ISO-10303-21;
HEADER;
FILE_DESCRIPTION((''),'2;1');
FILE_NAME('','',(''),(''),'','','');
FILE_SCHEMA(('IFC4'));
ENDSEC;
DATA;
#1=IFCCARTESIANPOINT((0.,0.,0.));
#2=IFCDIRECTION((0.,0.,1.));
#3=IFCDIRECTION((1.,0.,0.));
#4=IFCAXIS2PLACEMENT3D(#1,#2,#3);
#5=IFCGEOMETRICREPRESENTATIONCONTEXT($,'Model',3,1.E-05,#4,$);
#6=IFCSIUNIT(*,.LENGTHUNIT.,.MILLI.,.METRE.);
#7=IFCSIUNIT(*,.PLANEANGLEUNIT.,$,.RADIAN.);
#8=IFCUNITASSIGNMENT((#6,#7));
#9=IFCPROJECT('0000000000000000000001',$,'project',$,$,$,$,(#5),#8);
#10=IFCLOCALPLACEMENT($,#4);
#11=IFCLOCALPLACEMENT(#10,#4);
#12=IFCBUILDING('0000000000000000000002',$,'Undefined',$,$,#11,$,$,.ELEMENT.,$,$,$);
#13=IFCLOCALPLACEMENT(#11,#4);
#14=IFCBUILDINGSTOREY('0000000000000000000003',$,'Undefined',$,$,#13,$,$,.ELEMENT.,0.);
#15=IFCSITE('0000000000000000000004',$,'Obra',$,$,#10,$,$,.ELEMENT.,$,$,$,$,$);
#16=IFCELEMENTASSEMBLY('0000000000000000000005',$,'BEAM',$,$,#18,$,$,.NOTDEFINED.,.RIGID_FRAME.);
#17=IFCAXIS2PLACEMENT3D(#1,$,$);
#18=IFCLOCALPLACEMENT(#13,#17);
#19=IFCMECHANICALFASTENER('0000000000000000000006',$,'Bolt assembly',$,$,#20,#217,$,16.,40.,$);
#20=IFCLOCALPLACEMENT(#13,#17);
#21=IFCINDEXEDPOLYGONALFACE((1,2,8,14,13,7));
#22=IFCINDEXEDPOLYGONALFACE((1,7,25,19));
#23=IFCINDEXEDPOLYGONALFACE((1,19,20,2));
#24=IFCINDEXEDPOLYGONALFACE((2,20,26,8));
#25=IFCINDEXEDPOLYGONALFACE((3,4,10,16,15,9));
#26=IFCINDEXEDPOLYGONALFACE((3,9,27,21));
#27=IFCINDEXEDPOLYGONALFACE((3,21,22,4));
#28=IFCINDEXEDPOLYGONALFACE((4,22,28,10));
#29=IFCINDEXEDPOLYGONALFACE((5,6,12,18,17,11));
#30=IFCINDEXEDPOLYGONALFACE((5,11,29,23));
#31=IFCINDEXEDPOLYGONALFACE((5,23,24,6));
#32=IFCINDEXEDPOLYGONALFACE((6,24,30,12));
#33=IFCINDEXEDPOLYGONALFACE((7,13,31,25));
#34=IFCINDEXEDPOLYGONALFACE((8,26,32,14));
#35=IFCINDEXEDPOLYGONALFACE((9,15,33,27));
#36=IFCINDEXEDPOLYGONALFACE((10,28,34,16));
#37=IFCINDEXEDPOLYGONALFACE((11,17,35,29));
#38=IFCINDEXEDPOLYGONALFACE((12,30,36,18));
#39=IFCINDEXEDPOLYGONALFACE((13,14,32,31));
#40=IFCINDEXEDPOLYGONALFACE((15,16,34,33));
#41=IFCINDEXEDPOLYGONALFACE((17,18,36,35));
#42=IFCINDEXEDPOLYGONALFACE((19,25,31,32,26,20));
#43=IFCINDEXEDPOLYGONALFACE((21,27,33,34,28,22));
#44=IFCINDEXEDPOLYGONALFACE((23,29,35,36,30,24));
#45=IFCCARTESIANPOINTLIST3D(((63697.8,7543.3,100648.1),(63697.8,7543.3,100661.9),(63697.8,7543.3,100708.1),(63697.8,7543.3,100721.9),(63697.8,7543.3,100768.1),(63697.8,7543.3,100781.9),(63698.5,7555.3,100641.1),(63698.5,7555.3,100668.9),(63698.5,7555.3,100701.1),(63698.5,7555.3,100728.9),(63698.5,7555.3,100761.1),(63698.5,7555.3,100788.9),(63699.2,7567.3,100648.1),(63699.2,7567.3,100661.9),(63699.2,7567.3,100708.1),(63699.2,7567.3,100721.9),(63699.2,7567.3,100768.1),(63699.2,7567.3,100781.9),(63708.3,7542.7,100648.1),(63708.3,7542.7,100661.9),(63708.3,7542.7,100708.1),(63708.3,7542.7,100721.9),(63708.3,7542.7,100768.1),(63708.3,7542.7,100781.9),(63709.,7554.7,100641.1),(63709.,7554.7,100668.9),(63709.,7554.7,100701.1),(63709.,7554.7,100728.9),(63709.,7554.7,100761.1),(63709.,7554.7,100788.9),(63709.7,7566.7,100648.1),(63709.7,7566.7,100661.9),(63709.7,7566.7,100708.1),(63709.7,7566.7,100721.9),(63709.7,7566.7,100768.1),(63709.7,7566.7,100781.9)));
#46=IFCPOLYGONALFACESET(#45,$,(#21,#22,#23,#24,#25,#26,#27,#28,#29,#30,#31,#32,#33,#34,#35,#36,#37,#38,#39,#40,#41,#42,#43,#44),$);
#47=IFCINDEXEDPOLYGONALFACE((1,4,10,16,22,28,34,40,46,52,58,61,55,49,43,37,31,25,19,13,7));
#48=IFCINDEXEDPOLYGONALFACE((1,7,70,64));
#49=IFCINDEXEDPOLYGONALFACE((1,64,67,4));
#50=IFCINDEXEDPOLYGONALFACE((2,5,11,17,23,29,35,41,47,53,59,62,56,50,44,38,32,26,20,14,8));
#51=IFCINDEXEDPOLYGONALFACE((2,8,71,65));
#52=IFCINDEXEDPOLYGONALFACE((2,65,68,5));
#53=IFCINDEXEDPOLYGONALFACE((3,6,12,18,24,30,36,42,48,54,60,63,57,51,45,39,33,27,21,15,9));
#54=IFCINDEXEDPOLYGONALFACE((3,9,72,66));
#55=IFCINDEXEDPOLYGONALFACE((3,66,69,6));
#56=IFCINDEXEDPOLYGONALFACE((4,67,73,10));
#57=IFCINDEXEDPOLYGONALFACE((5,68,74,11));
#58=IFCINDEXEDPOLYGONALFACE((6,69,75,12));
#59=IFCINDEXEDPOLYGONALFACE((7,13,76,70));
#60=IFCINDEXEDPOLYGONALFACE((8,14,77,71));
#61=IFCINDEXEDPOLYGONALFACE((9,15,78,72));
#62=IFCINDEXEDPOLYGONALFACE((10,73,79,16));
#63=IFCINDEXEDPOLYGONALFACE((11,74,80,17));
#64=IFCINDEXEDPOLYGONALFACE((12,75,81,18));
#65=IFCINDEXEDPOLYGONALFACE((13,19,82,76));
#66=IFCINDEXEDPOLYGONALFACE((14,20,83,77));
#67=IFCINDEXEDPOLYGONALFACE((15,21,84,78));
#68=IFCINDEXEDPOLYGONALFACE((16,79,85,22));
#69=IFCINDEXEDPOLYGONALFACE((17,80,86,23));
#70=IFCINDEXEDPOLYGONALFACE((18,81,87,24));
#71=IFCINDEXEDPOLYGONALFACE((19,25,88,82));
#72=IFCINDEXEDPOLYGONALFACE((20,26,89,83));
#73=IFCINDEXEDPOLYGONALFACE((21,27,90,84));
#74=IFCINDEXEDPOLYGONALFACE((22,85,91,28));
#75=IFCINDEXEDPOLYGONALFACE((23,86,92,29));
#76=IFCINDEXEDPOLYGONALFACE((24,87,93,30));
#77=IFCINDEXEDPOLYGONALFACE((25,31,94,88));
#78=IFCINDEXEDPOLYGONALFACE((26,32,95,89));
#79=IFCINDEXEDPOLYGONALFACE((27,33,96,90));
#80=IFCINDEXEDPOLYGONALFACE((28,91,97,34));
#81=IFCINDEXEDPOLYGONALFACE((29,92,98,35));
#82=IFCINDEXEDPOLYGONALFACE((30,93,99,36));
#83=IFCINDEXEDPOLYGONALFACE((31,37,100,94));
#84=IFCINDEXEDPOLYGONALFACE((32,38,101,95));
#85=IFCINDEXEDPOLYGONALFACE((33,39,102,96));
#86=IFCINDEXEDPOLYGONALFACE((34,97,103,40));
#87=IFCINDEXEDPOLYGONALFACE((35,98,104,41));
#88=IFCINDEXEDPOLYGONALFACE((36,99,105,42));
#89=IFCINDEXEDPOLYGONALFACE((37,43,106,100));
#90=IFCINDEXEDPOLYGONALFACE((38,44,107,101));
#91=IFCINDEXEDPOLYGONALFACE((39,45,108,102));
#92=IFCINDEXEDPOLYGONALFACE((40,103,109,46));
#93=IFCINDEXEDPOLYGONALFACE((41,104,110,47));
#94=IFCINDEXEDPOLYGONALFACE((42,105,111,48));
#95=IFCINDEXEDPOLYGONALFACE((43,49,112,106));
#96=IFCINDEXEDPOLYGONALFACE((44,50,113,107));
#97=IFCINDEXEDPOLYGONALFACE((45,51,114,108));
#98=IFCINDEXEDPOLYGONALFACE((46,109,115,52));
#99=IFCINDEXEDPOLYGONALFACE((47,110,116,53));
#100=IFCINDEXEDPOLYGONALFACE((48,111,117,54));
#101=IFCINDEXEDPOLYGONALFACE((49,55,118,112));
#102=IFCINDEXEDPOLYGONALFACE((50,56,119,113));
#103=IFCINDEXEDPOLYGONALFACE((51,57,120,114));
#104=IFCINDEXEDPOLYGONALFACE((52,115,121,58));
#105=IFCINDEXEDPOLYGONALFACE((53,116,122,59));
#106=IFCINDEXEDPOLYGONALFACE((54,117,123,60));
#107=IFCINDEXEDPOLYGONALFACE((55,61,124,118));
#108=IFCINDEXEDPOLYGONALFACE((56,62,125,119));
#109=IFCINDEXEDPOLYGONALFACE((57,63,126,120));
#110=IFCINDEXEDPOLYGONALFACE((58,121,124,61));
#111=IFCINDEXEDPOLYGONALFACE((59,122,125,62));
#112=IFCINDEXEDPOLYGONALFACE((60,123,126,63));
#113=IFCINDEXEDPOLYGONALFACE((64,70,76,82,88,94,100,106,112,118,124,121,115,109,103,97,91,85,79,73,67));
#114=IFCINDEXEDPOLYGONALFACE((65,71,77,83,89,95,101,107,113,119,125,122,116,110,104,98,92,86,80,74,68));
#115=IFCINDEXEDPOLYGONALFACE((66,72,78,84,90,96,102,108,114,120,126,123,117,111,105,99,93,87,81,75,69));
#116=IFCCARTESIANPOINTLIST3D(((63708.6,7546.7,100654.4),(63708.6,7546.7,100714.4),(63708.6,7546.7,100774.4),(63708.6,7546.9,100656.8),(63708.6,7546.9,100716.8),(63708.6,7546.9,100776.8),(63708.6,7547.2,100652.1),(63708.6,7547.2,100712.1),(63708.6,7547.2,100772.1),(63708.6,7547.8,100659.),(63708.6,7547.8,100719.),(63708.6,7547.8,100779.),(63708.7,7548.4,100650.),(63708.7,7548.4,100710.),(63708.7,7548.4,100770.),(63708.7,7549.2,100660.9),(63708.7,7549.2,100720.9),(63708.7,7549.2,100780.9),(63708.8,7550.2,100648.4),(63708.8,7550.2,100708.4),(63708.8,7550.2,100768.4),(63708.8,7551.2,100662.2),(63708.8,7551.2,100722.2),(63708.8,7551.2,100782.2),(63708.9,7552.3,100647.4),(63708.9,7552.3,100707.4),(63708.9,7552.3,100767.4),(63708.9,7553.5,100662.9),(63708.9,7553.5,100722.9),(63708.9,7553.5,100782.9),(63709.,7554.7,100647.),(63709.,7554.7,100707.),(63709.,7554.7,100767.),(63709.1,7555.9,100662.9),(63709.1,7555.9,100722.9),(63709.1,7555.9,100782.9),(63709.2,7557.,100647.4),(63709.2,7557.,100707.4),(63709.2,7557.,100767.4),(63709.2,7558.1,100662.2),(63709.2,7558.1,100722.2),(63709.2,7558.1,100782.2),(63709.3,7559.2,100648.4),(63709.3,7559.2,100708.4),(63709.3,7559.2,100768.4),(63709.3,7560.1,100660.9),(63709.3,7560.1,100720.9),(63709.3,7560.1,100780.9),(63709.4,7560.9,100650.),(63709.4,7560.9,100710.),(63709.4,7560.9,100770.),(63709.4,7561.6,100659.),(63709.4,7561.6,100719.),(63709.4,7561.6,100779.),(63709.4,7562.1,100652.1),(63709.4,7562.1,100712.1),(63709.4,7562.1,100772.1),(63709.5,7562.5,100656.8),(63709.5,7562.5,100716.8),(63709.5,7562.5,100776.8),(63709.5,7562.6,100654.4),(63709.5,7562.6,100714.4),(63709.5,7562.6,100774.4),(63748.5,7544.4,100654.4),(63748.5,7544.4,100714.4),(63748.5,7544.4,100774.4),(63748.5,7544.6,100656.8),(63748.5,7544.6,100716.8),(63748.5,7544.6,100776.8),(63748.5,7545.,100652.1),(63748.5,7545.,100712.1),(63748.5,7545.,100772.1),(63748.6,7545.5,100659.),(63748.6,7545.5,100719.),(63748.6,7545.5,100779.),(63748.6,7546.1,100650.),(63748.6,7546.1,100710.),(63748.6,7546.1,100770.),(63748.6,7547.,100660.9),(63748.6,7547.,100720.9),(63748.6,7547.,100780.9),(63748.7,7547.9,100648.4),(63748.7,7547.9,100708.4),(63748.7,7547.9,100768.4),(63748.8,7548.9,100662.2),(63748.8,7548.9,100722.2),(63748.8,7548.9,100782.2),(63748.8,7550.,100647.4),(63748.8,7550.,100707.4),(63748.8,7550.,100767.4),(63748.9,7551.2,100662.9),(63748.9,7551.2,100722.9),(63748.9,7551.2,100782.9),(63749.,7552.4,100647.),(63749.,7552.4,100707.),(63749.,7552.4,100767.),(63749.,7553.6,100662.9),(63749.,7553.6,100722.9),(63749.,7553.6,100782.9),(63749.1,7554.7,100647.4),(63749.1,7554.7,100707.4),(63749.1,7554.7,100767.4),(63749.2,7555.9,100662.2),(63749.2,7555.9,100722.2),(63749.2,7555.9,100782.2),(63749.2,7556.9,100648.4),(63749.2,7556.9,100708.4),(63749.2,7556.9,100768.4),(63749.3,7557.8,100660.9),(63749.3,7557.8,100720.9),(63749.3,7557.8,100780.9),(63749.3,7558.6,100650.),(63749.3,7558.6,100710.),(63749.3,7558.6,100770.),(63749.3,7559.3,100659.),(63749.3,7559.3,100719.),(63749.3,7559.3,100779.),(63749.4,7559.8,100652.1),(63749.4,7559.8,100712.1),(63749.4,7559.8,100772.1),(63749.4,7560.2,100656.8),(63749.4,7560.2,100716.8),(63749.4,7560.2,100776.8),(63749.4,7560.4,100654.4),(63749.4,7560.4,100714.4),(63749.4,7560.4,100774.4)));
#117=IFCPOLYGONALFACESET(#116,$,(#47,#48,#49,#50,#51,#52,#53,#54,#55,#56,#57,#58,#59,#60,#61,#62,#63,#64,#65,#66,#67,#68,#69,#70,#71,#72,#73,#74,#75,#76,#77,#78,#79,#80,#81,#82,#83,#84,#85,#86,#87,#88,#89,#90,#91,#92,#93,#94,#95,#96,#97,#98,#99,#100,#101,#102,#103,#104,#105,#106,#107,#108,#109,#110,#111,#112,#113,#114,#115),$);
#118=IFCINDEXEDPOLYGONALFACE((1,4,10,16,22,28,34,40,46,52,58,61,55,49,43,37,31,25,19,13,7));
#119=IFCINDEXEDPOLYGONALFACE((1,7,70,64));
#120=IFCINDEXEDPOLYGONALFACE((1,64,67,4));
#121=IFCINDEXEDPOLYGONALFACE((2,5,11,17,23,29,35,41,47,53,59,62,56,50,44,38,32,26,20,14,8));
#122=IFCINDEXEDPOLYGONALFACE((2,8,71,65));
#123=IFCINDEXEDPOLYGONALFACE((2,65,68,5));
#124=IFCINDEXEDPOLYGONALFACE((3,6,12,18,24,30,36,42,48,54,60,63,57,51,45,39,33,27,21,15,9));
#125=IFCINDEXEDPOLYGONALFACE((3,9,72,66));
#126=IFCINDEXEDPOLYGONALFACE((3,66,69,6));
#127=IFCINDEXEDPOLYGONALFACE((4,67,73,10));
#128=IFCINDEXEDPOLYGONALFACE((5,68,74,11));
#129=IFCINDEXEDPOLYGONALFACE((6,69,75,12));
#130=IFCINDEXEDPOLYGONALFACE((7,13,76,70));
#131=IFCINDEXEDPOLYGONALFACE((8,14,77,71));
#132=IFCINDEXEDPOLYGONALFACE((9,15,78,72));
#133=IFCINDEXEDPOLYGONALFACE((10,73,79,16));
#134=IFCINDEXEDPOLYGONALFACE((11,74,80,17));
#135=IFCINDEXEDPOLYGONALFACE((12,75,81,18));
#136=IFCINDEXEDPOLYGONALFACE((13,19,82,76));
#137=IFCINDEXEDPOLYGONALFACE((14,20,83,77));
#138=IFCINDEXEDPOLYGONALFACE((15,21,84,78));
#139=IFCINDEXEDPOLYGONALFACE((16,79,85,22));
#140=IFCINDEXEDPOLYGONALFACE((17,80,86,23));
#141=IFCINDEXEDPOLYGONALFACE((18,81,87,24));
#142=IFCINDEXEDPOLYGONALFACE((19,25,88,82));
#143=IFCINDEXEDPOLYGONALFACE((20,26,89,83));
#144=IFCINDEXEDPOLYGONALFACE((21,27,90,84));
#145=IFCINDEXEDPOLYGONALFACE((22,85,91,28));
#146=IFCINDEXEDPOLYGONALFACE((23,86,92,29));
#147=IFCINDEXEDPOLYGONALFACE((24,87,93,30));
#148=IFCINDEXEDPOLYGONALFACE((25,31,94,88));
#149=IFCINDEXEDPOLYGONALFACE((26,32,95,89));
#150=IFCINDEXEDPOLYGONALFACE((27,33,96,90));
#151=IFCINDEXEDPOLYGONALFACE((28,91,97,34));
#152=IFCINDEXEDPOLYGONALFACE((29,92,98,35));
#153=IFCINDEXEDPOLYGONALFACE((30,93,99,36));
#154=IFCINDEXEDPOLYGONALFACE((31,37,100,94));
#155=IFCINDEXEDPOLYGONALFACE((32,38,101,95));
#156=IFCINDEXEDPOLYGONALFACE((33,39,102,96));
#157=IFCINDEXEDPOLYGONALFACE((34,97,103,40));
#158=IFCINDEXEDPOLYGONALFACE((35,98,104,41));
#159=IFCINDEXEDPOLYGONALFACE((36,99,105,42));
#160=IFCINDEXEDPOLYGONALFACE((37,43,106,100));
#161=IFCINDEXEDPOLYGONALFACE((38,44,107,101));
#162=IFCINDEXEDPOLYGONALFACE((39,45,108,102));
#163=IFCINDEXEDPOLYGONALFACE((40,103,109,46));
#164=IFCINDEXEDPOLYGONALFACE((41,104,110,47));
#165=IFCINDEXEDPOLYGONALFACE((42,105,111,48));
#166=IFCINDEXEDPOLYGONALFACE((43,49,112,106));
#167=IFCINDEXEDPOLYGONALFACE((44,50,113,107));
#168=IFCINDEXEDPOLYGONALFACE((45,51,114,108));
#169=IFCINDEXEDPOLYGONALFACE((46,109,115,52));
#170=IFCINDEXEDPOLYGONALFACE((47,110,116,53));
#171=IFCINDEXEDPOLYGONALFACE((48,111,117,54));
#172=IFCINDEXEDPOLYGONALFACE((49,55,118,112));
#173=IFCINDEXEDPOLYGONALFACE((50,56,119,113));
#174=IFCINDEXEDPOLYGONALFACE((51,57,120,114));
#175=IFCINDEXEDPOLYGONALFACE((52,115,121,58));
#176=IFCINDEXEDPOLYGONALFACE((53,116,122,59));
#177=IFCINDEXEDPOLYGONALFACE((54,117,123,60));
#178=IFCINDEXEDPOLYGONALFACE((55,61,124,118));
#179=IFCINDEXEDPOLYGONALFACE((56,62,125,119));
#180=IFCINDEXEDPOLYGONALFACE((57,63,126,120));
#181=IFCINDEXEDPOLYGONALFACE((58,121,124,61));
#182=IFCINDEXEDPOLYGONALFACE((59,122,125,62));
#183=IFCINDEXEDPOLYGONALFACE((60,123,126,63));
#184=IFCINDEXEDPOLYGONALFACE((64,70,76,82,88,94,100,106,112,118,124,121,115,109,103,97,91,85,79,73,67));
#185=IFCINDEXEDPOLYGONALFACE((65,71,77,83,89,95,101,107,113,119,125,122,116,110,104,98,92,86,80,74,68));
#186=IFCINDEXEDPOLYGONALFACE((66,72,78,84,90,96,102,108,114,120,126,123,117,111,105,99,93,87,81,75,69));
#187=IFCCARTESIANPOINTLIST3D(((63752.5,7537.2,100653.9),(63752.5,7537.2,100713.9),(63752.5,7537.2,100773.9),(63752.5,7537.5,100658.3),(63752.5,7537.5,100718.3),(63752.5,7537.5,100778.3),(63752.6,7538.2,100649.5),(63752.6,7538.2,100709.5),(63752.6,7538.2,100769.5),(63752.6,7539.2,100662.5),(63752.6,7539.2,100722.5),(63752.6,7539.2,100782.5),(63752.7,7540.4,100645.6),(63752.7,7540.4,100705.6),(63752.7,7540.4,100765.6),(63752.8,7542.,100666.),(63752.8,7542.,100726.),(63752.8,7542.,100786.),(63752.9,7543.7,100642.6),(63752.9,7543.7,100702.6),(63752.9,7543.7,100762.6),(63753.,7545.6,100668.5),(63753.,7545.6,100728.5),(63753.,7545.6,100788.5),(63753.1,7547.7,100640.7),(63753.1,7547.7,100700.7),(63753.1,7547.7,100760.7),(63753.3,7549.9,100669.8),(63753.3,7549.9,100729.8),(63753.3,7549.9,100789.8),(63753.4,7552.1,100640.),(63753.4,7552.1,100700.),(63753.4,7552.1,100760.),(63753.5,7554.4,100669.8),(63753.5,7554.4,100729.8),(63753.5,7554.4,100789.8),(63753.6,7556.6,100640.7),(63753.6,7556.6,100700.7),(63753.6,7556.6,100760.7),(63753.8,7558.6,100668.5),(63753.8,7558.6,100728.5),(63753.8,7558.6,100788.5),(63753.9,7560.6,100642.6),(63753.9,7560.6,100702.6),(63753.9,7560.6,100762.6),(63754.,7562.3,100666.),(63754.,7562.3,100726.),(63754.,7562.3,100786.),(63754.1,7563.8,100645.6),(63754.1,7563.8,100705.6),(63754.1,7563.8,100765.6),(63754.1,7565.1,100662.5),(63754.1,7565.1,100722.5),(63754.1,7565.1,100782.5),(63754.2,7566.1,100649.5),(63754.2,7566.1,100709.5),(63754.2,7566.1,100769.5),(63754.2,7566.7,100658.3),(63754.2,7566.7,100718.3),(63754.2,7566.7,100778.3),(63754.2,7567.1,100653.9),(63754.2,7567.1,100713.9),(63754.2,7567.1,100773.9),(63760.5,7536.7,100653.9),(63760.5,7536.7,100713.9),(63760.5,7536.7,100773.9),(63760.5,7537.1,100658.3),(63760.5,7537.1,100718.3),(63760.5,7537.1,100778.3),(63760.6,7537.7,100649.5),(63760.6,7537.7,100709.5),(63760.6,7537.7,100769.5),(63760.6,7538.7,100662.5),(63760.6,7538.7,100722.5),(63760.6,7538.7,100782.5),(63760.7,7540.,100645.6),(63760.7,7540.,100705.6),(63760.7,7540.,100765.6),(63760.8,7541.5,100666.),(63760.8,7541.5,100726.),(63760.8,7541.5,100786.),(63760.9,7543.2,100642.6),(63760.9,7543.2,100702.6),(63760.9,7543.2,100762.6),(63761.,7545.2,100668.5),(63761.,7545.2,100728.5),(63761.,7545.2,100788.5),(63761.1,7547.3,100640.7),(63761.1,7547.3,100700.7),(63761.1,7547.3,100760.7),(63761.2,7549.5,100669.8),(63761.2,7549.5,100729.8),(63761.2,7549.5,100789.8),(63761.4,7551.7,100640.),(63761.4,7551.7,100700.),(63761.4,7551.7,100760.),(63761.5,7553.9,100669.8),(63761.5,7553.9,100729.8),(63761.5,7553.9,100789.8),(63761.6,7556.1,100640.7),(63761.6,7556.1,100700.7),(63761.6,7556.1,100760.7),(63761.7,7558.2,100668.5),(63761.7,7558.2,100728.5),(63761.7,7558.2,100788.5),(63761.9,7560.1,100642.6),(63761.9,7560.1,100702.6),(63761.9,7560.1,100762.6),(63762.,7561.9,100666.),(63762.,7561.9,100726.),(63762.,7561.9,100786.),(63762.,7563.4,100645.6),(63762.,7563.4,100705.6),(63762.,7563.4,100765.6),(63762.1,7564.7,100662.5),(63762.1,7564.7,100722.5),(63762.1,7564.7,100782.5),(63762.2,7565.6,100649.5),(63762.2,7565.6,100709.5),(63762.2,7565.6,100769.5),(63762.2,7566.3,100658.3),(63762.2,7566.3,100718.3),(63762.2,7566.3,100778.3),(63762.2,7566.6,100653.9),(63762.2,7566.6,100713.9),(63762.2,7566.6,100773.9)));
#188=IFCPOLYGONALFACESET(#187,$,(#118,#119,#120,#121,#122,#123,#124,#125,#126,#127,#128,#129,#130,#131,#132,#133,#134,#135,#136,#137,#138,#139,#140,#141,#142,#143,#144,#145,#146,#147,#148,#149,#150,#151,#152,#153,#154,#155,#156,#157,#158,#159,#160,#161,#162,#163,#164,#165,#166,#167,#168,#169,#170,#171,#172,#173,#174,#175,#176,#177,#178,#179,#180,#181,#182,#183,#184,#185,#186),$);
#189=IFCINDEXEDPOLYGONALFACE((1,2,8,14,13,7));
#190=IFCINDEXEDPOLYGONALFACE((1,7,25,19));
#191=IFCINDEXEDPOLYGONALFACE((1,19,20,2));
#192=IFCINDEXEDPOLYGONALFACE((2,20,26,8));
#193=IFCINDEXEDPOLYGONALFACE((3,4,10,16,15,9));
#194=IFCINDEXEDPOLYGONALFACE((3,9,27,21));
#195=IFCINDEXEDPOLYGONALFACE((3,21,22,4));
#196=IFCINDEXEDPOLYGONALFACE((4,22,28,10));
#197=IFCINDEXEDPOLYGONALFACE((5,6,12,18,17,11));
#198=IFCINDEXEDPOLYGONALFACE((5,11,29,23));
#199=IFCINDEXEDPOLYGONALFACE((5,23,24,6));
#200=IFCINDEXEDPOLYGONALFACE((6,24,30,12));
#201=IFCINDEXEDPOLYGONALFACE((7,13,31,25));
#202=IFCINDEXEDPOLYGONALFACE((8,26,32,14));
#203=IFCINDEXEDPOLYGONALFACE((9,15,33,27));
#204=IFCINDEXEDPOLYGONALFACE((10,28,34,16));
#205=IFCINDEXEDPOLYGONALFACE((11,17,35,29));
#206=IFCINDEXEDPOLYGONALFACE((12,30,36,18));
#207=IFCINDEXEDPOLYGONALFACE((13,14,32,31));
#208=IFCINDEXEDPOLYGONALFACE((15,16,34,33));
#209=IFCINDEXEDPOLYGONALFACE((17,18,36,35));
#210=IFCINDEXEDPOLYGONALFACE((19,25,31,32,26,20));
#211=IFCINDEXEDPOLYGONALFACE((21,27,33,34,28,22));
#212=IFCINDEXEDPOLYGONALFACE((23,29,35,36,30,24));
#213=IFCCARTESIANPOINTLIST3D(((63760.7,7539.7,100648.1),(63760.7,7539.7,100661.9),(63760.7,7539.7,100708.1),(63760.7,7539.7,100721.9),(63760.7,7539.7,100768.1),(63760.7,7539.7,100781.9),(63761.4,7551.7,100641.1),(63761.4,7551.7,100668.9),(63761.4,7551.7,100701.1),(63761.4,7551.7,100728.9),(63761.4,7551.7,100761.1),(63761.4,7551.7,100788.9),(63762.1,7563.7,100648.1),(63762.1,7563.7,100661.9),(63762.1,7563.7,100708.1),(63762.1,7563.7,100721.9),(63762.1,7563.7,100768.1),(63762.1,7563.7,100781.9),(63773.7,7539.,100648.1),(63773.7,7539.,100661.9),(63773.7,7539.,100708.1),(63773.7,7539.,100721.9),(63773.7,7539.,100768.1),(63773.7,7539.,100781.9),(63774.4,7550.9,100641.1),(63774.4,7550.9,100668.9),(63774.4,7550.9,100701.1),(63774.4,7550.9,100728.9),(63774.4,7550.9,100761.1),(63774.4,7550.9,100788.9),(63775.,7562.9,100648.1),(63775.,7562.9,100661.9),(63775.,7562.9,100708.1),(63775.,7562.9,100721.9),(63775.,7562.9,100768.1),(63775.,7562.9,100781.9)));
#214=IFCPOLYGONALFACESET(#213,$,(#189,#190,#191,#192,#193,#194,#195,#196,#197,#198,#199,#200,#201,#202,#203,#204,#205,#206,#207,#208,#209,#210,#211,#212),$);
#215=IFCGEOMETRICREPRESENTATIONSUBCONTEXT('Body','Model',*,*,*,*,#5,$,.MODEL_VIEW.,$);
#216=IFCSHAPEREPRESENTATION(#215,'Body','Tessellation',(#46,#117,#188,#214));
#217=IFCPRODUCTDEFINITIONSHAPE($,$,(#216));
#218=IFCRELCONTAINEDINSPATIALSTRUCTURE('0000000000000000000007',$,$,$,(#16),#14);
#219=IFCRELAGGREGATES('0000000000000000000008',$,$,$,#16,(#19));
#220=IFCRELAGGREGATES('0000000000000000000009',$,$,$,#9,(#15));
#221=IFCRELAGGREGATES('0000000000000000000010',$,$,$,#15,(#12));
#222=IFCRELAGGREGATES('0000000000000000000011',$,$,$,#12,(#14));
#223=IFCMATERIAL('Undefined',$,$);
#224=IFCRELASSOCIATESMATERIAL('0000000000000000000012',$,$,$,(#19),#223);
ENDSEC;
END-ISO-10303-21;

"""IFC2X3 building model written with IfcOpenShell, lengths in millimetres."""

from ifc_helpers import new_model, si_unit, frame, origin_with_axes, origin_2d_with_axis, place, context, subcontext, project, spatial, polyline, circle, outline, extrude, source, transform, mapped, material, element, aggregate, save


model = new_model("IFC2X3")

# Units and contexts
model_context = context("Model", 3, precision=1e-05, world=origin_with_axes())
body_context = subcontext(model_context, "Body", "Model", "MODEL_VIEW")
ifc_project = project(units=[si_unit("LENGTHUNIT", "METRE", prefix="MILLI"), si_unit("PLANEANGLEUNIT", "RADIAN")], contexts=[model_context])

# Site, building, storey
site_placement = place(None, origin_with_axes())
site = spatial("IfcSite", under=ifc_project, at=site_placement, Name="Obra", CompositionType="ELEMENT")
building_placement = place(site_placement, origin_with_axes())
building = spatial("IfcBuilding", under=site, at=building_placement, Name="Undefined", CompositionType="ELEMENT")
storey_placement = place(building_placement, origin_with_axes())
storey = spatial("IfcBuildingStorey", under=building, at=storey_placement, Name="Undefined", CompositionType="ELEMENT", Elevation=0.0)

# Shared definitions
ifc_material_1 = material(Name="Undefined")

# Element assembly
assembly_1_placement = place(storey_placement, origin_with_axes())
assembly_1 = element("IfcElementAssembly", 1, at=assembly_1_placement, inside=storey, Name="BEAM", AssemblyPlace="NOTDEFINED", PredefinedType="RIGID_FRAME")

# Shared definitions
shared_shape_1 = source(origin_with_axes(), body_context, "Body", "SweptSolid", [
    extrude(outline(polyline([(13.9, 0.0), (6.9, 12.0), (-6.9, 12.0), (-13.9, 0.0), (-6.9, -12.0), (6.9, -12.0), (13.9, 0.0)])), frame((0.0, -19.7, 0.0), z_axis=(0.0, 1.0, 0.0), x_axis=(1.0, 0.0, 0.0)), (0.0, 0.0, 1.0), 10.6),
    extrude(circle(Radius=8.0, at=origin_2d_with_axis()), frame((0.0, -9.1, 0.0), z_axis=(0.0, 1.0, 0.0), x_axis=(1.0, 0.0, 0.0)), (0.0, 0.0, 1.0), 40.0),
    extrude(circle(Radius=15.0, at=origin_2d_with_axis()), frame((0.0, 35.3, 0.0), z_axis=(0.0, 1.0, 0.0), x_axis=(1.0, 0.0, 0.0)), (0.0, 0.0, 1.0), 8.0),
    extrude(outline(polyline([(13.9, 0.0), (6.9, 12.0), (-6.9, 12.0), (-13.9, 0.0), (-6.9, -12.0), (6.9, -12.0), (13.9, 0.0)])), frame((0.0, 43.3, 0.0), z_axis=(0.0, 1.0, 0.0), x_axis=(1.0, 0.0, 0.0)), (0.0, 0.0, 1.0), 13.0),
])

# Mechanical fastener
mechanical_fastener_1_placement = place(assembly_1_placement, frame((63721.0, 7604.1, 100835.0), z_axis=(-0.05711, -0.998368, 0.0), x_axis=(0.0, 0.0, -1.0)))
mechanical_fastener_1 = element("IfcMechanicalFastener", 2, at=mechanical_fastener_1_placement, material=ifc_material_1, Name="Bolt assembly", NominalDiameter=16.0, NominalLength=40.0, context=body_context, shape_type="MappedRepresentation", body=[
    mapped(shared_shape_1, transform((60.0, 0.0, 50.0))),
    mapped(shared_shape_1, transform((120.0, 0.0, 50.0))),
    mapped(shared_shape_1, transform((180.0, 0.0, 50.0))),
])
aggregate(assembly_1, [mechanical_fastener_1])

save(model, "model.ifc")
